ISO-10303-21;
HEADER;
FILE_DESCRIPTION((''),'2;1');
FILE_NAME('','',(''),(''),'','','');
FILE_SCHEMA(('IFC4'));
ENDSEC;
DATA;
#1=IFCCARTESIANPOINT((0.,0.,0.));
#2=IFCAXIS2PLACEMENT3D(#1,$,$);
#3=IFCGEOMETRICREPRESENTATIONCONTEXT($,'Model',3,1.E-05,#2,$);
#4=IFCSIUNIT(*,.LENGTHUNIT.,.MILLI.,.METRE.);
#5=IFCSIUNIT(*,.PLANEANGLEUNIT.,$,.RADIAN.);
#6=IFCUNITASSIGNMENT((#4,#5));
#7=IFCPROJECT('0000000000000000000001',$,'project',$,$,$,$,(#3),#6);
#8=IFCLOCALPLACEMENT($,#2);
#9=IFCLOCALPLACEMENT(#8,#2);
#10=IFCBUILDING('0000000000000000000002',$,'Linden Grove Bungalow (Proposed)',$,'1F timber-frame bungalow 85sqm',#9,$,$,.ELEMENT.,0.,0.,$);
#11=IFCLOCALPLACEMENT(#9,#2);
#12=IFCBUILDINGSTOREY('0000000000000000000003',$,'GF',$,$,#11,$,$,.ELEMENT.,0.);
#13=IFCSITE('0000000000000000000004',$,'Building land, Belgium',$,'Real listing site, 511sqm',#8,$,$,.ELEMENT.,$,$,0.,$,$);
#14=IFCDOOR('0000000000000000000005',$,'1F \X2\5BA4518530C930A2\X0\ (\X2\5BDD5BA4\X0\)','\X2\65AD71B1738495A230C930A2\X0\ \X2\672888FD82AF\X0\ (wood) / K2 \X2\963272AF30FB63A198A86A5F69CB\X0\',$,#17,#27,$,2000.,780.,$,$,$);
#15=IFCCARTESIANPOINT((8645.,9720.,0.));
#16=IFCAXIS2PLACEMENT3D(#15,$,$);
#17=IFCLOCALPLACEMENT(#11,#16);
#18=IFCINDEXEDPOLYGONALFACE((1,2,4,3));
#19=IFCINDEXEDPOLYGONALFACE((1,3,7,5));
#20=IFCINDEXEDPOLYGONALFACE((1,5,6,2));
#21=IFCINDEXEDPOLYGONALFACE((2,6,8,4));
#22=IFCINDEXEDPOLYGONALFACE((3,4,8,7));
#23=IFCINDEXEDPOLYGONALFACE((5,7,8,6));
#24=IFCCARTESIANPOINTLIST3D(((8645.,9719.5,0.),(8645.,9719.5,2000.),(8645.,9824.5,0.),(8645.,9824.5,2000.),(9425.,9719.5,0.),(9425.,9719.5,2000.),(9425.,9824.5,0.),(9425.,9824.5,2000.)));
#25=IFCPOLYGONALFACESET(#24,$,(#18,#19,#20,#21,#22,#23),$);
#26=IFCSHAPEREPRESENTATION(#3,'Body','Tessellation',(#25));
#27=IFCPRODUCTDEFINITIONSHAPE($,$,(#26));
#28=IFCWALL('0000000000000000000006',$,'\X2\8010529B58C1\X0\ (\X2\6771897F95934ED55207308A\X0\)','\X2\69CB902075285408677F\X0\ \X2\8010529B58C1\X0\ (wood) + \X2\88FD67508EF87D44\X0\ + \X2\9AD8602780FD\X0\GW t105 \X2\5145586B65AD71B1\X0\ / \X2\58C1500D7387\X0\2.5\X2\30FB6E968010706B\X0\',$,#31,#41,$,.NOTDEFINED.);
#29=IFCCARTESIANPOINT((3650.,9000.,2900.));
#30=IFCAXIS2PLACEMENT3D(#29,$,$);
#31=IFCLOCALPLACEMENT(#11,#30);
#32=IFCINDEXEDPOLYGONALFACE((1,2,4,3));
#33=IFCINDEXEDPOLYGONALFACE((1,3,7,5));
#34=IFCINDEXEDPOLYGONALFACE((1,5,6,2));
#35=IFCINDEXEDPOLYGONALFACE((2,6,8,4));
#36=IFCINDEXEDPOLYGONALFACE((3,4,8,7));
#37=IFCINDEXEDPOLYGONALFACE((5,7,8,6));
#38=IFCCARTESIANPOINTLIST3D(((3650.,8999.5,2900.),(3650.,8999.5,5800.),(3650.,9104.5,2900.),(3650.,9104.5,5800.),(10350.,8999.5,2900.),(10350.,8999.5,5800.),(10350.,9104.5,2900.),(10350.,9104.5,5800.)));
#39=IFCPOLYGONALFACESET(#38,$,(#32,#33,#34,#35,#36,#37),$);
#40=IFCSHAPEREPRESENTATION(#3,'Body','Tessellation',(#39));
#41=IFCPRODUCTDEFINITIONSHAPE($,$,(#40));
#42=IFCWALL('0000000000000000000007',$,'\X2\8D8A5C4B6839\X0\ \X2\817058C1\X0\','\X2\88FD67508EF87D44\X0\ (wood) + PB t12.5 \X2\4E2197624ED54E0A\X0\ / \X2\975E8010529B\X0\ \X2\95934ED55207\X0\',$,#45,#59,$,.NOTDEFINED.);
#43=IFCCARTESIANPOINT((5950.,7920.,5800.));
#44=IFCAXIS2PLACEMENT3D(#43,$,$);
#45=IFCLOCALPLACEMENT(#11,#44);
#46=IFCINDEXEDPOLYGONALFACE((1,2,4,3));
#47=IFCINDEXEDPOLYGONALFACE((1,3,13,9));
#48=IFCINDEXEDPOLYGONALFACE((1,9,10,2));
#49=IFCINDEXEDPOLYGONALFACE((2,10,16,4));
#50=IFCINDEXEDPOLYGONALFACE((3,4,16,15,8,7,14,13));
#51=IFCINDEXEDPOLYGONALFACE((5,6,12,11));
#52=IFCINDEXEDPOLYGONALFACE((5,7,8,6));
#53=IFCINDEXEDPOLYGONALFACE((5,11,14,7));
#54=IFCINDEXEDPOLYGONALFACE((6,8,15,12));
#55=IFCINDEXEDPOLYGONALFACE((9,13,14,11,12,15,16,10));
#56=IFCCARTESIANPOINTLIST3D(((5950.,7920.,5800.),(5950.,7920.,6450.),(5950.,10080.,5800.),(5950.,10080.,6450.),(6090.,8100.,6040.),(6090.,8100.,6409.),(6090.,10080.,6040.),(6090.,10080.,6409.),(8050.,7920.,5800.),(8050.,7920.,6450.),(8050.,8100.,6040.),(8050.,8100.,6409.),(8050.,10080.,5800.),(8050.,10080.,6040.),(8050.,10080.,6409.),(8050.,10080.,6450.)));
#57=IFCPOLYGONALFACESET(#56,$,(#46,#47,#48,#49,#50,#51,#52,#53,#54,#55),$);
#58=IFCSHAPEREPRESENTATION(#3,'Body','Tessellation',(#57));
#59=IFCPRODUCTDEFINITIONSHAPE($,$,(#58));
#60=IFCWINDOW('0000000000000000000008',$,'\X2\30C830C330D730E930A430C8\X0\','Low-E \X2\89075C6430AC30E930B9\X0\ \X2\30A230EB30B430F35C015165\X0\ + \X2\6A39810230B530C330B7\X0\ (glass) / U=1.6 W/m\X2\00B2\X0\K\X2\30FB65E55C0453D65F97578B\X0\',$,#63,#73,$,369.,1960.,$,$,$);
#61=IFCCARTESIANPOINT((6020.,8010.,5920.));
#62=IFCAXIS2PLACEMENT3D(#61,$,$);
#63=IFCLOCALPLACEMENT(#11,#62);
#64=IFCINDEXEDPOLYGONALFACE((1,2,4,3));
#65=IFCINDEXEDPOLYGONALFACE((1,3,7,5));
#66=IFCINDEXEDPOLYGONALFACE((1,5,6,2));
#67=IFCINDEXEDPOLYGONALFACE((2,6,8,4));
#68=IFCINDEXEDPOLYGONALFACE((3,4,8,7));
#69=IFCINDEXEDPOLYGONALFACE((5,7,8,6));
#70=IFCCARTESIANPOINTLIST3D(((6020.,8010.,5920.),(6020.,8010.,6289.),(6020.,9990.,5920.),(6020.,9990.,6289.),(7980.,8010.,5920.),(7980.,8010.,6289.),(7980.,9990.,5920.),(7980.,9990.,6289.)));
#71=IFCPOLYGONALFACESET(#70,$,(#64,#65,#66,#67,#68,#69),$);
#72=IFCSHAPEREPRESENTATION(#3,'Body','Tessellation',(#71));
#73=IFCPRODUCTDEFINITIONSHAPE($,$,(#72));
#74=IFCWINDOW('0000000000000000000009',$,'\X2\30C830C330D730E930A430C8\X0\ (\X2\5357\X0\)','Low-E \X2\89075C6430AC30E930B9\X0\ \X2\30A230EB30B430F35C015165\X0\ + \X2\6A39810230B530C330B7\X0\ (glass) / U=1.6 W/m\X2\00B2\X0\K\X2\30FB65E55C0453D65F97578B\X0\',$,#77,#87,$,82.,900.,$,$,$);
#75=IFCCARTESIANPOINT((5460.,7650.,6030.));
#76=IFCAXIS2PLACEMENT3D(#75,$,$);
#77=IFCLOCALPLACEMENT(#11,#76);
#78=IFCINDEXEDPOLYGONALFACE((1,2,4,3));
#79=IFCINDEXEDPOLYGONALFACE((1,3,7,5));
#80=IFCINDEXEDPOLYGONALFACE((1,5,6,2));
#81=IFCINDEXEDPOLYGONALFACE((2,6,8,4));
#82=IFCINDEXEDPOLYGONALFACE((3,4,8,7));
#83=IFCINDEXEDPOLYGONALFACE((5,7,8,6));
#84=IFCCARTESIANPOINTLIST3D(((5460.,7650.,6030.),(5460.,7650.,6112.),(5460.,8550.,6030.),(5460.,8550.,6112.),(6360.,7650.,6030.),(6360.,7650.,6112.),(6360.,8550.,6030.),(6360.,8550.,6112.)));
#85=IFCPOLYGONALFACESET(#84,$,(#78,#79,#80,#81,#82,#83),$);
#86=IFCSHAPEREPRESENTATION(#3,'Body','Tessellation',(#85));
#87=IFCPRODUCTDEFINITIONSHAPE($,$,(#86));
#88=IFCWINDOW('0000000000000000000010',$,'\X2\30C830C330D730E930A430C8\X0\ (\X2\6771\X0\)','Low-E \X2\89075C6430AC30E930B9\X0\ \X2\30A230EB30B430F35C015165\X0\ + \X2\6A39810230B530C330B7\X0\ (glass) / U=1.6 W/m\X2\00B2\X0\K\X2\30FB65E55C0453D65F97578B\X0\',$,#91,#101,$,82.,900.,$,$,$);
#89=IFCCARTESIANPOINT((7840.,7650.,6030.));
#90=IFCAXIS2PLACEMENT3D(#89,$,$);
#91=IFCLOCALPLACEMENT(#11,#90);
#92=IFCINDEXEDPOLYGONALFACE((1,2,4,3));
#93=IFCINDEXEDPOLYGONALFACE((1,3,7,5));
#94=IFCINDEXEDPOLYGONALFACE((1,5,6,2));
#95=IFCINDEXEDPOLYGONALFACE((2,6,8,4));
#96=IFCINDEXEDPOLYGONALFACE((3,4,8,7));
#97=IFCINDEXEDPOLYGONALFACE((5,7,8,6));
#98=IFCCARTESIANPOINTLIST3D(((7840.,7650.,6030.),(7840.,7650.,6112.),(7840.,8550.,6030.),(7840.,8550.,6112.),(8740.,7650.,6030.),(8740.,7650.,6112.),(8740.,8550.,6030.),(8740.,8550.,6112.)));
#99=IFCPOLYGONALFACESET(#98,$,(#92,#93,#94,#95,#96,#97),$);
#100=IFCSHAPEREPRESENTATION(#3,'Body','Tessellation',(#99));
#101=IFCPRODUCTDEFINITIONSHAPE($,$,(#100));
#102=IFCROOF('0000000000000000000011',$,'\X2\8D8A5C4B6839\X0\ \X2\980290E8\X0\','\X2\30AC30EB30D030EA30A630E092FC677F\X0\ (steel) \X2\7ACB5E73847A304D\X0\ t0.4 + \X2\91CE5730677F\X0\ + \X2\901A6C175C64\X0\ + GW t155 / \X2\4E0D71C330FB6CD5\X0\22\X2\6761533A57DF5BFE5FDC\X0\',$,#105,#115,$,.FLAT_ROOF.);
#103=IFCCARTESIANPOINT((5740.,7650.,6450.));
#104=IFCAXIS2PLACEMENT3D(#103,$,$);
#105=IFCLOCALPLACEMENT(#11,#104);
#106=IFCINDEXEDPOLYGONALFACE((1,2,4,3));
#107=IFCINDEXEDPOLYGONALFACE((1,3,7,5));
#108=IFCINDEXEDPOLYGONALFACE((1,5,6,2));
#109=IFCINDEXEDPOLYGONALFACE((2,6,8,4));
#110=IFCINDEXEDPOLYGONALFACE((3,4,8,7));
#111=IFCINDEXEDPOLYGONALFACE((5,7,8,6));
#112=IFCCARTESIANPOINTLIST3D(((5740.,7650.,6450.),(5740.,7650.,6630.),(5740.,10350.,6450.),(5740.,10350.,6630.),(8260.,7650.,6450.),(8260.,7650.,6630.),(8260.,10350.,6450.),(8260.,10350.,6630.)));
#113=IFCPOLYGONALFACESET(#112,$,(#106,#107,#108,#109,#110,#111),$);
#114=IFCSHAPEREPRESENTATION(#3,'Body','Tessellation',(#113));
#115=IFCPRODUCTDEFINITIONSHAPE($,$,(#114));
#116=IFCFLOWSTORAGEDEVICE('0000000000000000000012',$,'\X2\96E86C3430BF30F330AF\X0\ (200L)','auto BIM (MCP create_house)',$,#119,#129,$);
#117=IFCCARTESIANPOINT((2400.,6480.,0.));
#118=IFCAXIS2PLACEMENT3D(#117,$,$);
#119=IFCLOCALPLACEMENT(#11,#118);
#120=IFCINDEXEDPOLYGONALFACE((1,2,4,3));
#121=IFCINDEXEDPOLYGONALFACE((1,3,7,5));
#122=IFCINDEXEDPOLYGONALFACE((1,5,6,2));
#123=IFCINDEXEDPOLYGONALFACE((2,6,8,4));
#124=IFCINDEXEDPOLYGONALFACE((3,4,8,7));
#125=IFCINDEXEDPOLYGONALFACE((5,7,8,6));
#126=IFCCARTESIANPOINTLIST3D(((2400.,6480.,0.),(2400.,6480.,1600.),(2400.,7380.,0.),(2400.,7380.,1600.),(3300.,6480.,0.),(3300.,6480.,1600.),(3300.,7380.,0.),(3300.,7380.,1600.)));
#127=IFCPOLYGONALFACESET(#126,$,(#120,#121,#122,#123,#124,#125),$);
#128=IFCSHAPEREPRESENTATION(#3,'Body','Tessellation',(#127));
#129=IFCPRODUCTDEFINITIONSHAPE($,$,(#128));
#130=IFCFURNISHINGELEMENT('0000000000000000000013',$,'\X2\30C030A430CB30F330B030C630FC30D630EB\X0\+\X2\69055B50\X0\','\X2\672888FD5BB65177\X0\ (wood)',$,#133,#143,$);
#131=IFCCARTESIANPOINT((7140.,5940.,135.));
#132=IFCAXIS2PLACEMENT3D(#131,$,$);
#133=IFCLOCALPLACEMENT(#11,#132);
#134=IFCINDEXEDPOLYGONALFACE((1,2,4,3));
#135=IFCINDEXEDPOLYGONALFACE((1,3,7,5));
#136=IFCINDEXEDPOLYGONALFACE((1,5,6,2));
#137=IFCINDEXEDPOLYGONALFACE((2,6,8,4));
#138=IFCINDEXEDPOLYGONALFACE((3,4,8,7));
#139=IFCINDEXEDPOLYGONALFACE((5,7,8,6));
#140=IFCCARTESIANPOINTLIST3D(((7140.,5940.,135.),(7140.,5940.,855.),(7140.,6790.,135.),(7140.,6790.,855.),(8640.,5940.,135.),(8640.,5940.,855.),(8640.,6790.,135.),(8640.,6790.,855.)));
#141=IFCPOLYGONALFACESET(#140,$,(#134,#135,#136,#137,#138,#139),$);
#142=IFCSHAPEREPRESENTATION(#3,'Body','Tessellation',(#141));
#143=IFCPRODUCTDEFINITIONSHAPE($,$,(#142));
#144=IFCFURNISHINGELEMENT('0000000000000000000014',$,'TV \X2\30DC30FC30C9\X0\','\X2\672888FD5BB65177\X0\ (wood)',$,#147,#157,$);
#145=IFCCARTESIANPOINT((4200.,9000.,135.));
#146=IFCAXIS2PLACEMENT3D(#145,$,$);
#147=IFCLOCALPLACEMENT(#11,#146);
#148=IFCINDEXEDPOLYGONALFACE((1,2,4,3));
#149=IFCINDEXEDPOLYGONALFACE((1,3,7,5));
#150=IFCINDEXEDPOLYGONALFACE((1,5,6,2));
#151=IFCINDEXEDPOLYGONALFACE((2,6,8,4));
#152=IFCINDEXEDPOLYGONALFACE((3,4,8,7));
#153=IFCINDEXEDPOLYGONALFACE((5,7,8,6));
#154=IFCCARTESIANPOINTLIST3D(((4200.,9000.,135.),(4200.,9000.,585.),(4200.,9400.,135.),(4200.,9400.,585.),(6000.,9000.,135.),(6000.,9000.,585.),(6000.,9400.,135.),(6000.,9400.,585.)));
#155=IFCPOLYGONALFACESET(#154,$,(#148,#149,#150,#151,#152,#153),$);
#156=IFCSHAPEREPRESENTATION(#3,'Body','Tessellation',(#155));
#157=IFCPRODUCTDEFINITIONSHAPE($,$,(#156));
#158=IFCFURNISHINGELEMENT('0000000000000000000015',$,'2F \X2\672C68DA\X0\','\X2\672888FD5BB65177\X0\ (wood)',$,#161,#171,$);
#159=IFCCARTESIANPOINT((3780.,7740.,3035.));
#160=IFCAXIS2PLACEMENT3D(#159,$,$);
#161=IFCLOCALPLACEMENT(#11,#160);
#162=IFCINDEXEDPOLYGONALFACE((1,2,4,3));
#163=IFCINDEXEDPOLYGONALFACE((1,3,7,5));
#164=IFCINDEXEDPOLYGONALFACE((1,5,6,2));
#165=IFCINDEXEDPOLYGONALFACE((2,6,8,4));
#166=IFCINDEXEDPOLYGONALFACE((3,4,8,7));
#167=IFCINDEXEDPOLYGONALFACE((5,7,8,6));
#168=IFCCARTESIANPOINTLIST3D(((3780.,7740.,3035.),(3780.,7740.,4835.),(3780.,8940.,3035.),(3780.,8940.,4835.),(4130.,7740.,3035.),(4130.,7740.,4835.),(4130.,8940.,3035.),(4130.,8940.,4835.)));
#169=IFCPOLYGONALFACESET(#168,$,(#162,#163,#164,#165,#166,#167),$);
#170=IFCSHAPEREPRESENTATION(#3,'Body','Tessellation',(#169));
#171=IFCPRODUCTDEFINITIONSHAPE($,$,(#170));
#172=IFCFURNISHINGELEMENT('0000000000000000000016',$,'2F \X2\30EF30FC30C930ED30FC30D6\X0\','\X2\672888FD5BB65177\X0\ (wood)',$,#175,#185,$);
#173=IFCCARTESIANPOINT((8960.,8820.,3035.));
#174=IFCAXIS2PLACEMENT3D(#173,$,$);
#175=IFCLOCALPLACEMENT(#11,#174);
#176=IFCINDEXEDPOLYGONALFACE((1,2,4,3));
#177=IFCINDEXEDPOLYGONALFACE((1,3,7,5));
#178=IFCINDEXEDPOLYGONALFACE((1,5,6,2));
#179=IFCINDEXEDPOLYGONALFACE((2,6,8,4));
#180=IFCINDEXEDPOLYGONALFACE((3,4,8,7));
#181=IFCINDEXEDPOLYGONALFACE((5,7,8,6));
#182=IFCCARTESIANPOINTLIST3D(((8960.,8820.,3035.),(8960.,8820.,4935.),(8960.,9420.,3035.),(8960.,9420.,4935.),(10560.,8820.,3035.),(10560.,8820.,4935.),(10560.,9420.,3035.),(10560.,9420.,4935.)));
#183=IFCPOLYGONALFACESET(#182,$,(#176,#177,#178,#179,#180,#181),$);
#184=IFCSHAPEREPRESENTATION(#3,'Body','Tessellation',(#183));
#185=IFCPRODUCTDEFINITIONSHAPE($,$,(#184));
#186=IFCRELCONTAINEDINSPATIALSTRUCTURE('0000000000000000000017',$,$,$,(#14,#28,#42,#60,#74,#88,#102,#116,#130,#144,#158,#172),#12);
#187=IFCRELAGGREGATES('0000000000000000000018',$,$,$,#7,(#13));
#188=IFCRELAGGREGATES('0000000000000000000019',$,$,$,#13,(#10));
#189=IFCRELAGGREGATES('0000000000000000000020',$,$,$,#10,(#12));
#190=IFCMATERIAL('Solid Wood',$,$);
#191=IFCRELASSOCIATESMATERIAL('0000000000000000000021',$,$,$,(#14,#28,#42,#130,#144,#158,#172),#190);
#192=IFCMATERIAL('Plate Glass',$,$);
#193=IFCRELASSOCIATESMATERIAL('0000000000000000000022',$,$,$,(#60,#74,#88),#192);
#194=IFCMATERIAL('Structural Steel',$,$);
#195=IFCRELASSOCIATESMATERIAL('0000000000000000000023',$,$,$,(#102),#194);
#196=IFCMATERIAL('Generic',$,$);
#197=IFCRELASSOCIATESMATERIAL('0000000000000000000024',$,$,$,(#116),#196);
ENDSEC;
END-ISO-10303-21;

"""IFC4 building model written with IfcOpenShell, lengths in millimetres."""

from ifc_helpers import new_model, si_unit, frame, frame_2d, origin, place, context, project, spatial, rectangle, extrude, material, element, fill, save


model = new_model("IFC4")

# Units and contexts
model_context = context("Model", 3, precision=1e-05, world=origin())
ifc_project = project(units=[si_unit("LENGTHUNIT", "METRE", prefix="MILLI"), si_unit("PLANEANGLEUNIT", "RADIAN")], contexts=[model_context])

# Site, building, storey
site_placement = place(None, origin())
site = spatial("IfcSite", under=ifc_project, at=site_placement, Name="Building land, Belgium", ObjectType="Real listing site, 511sqm", CompositionType="ELEMENT", RefElevation=0.0)
building_placement = place(site_placement, origin())
building = spatial("IfcBuilding", under=site, at=building_placement, Name="Linden Grove Bungalow (Proposed)", ObjectType="1F timber-frame bungalow 85sqm", CompositionType="ELEMENT", ElevationOfRefHeight=0.0, ElevationOfTerrain=0.0)
storey_placement = place(building_placement, origin())
storey = spatial("IfcBuildingStorey", under=building, at=storey_placement, Name="GF", CompositionType="ELEMENT", Elevation=0.0)

# Shared definitions
ifc_material_1 = material(Name="Solid Wood")

# Door
door_placement = place(storey_placement, frame((8645.0, 9720.0, 0.0)))
element("IfcDoor", 1, at=door_placement, inside=storey, material=ifc_material_1, Name="1F 室内ドア (寝室)", Description="断熱玄関ドア 木製芯 (wood) / K2 防犯・採風機構", OverallHeight=2000.0, OverallWidth=780.0, context=model_context, shape_type="SweptSolid", body=[
    extrude(rectangle(XDim=780.0, YDim=105.0, at=frame_2d((390.0, 52.0))), frame((8645.0, 9720.0, 0.0)), (0.0, 0.0, 1.0), 2000.0),
])

# Wall
wall_1_placement = place(storey_placement, frame((3650.0, 9000.0, 2900.0)))
element("IfcWall", 2, at=wall_1_placement, inside=storey, material=ifc_material_1, Name="耐力壁 (東西間仕切り)", Description="構造用合板 耐力壁 (wood) + 製材軸組 + 高性能GW t105 充填断熱 / 壁倍率2.5・準耐火", PredefinedType="NOTDEFINED", context=model_context, shape_type="SweptSolid", body=[
    extrude(rectangle(XDim=6700.0, YDim=105.0, at=frame_2d((3350.0, 52.0))), frame((3650.0, 9000.0, 2900.0)), (0.0, 0.0, 1.0), 2900.0),
])

# Wall, openings, windows
wall_2_placement = place(storey_placement, frame((5950.0, 7920.0, 5800.0)))
wall_2 = element("IfcWall", 3, at=wall_2_placement, inside=storey, material=ifc_material_1, Name="越屋根 腰壁", Description="製材軸組 (wood) + PB t12.5 両面仕上 / 非耐力 間仕切", PredefinedType="NOTDEFINED", context=model_context, shape_type="SweptSolid", body=[
    extrude(rectangle(XDim=2100.0, YDim=2160.0, at=frame_2d((1050.0, 1080.0))), frame((5950.0, 7920.0, 5800.0)), (0.0, 0.0, 1.0), 650.0),
])
opening_1_placement = place(storey_placement, frame((6020.0, 8010.0, 5920.0)))
opening_1 = element("IfcOpeningElement", 4, at=opening_1_placement, cuts=wall_2, PredefinedType="NOTDEFINED", context=model_context, shape_type="SweptSolid", body=[
    extrude(rectangle(XDim=1960.0, YDim=1980.0, at=frame_2d((980.0, 990.0))), frame((6020.0, 8010.0, 5920.0)), (0.0, 0.0, 1.0), 369.0),
])
opening_2_placement = place(storey_placement, frame((5460.0, 7650.0, 6030.0)))
opening_2 = element("IfcOpeningElement", 5, at=opening_2_placement, cuts=wall_2, PredefinedType="NOTDEFINED", context=model_context, shape_type="SweptSolid", body=[
    extrude(rectangle(XDim=900.0, YDim=900.0, at=frame_2d((450.0, 450.0))), frame((5460.0, 7650.0, 6030.0)), (0.0, 0.0, 1.0), 82.0),
])
opening_3_placement = place(storey_placement, frame((7840.0, 7650.0, 6030.0)))
opening_3 = element("IfcOpeningElement", 6, at=opening_3_placement, cuts=wall_2, PredefinedType="NOTDEFINED", context=model_context, shape_type="SweptSolid", body=[
    extrude(rectangle(XDim=900.0, YDim=900.0, at=frame_2d((450.0, 450.0))), frame((7840.0, 7650.0, 6030.0)), (0.0, 0.0, 1.0), 82.0),
])
ifc_material_2 = material(Name="Plate Glass")
window_1_placement = place(storey_placement, frame((6020.0, 8010.0, 5920.0)))
window_1 = element("IfcWindow", 7, at=window_1_placement, inside=storey, material=ifc_material_2, Name="トップライト", Description="Low-E 複層ガラス アルゴン封入 + 樹脂サッシ (glass) / U=1.6 W/m²K・日射取得型", OverallHeight=369.0, OverallWidth=1960.0, context=model_context, shape_type="SweptSolid", body=[
    extrude(rectangle(XDim=1960.0, YDim=1980.0, at=frame_2d((980.0, 990.0))), frame((6020.0, 8010.0, 5920.0)), (0.0, 0.0, 1.0), 369.0),
])
fill(opening_1, window_1)
window_2_placement = place(storey_placement, frame((5460.0, 7650.0, 6030.0)))
window_2 = element("IfcWindow", 8, at=window_2_placement, inside=storey, material=ifc_material_2, Name="トップライト (南)", Description="Low-E 複層ガラス アルゴン封入 + 樹脂サッシ (glass) / U=1.6 W/m²K・日射取得型", OverallHeight=82.0, OverallWidth=900.0, context=model_context, shape_type="SweptSolid", body=[
    extrude(rectangle(XDim=900.0, YDim=900.0, at=frame_2d((450.0, 450.0))), frame((5460.0, 7650.0, 6030.0)), (0.0, 0.0, 1.0), 82.0),
])
fill(opening_2, window_2)
window_3_placement = place(storey_placement, frame((7840.0, 7650.0, 6030.0)))
window_3 = element("IfcWindow", 9, at=window_3_placement, inside=storey, material=ifc_material_2, Name="トップライト (東)", Description="Low-E 複層ガラス アルゴン封入 + 樹脂サッシ (glass) / U=1.6 W/m²K・日射取得型", OverallHeight=82.0, OverallWidth=900.0, context=model_context, shape_type="SweptSolid", body=[
    extrude(rectangle(XDim=900.0, YDim=900.0, at=frame_2d((450.0, 450.0))), frame((7840.0, 7650.0, 6030.0)), (0.0, 0.0, 1.0), 82.0),
])
fill(opening_3, window_3)

# Roof
ifc_material_3 = material(Name="Structural Steel")
roof_placement = place(storey_placement, frame((5740.0, 7650.0, 6450.0)))
element("IfcRoof", 10, at=roof_placement, inside=storey, material=ifc_material_3, Name="越屋根 頂部", Description="ガルバリウム鋼板 (steel) 立平葺き t0.4 + 野地板 + 通気層 + GW t155 / 不燃・法22条区域対応", PredefinedType="FLAT_ROOF", context=model_context, shape_type="SweptSolid", body=[
    extrude(rectangle(XDim=2520.0, YDim=2700.0, at=frame_2d((1260.0, 1350.0))), frame((5740.0, 7650.0, 6450.0)), (0.0, 0.0, 1.0), 180.0),
])

# Flow storage device
ifc_material_4 = material(Name="Generic")
flow_storage_device_placement = place(storey_placement, frame((2400.0, 6480.0, 0.0)))
element("IfcFlowStorageDevice", 11, at=flow_storage_device_placement, inside=storey, material=ifc_material_4, Name="雨水タンク (200L)", Description="auto BIM (MCP create_house)", context=model_context, shape_type="SweptSolid", body=[
    extrude(rectangle(XDim=900.0, YDim=900.0, at=frame_2d((450.0, 450.0))), frame((2400.0, 6480.0, 0.0)), (0.0, 0.0, 1.0), 1600.0),
])

# Furnishing elements
furnishing_1_placement = place(storey_placement, frame((7140.0, 5940.0, 135.0)))
element("IfcFurnishingElement", 12, at=furnishing_1_placement, inside=storey, material=ifc_material_1, Name="ダイニングテーブル+椅子", Description="木製家具 (wood)", context=model_context, shape_type="SweptSolid", body=[
    extrude(rectangle(XDim=1500.0, YDim=850.0, at=frame_2d((750.0, 425.0))), frame((7140.0, 5940.0, 135.0)), (0.0, 0.0, 1.0), 720.0),
])
furnishing_2_placement = place(storey_placement, frame((4200.0, 9000.0, 135.0)))
element("IfcFurnishingElement", 13, at=furnishing_2_placement, inside=storey, material=ifc_material_1, Name="TV ボード", Description="木製家具 (wood)", context=model_context, shape_type="SweptSolid", body=[
    extrude(rectangle(XDim=1800.0, YDim=400.0, at=frame_2d((900.0, 200.0))), frame((4200.0, 9000.0, 135.0)), (0.0, 0.0, 1.0), 450.0),
])
furnishing_3_placement = place(storey_placement, frame((3780.0, 7740.0, 3035.0)))
element("IfcFurnishingElement", 14, at=furnishing_3_placement, inside=storey, material=ifc_material_1, Name="2F 本棚", Description="木製家具 (wood)", context=model_context, shape_type="SweptSolid", body=[
    extrude(rectangle(XDim=350.0, YDim=1200.0, at=frame_2d((175.0, 600.0))), frame((3780.0, 7740.0, 3035.0)), (0.0, 0.0, 1.0), 1800.0),
])
furnishing_4_placement = place(storey_placement, frame((8960.0, 8820.0, 3035.0)))
element("IfcFurnishingElement", 15, at=furnishing_4_placement, inside=storey, material=ifc_material_1, Name="2F ワードローブ", Description="木製家具 (wood)", context=model_context, shape_type="SweptSolid", body=[
    extrude(rectangle(XDim=1600.0, YDim=600.0, at=frame_2d((800.0, 300.0))), frame((8960.0, 8820.0, 3035.0)), (0.0, 0.0, 1.0), 1900.0),
])

save(model, "model.ifc")
